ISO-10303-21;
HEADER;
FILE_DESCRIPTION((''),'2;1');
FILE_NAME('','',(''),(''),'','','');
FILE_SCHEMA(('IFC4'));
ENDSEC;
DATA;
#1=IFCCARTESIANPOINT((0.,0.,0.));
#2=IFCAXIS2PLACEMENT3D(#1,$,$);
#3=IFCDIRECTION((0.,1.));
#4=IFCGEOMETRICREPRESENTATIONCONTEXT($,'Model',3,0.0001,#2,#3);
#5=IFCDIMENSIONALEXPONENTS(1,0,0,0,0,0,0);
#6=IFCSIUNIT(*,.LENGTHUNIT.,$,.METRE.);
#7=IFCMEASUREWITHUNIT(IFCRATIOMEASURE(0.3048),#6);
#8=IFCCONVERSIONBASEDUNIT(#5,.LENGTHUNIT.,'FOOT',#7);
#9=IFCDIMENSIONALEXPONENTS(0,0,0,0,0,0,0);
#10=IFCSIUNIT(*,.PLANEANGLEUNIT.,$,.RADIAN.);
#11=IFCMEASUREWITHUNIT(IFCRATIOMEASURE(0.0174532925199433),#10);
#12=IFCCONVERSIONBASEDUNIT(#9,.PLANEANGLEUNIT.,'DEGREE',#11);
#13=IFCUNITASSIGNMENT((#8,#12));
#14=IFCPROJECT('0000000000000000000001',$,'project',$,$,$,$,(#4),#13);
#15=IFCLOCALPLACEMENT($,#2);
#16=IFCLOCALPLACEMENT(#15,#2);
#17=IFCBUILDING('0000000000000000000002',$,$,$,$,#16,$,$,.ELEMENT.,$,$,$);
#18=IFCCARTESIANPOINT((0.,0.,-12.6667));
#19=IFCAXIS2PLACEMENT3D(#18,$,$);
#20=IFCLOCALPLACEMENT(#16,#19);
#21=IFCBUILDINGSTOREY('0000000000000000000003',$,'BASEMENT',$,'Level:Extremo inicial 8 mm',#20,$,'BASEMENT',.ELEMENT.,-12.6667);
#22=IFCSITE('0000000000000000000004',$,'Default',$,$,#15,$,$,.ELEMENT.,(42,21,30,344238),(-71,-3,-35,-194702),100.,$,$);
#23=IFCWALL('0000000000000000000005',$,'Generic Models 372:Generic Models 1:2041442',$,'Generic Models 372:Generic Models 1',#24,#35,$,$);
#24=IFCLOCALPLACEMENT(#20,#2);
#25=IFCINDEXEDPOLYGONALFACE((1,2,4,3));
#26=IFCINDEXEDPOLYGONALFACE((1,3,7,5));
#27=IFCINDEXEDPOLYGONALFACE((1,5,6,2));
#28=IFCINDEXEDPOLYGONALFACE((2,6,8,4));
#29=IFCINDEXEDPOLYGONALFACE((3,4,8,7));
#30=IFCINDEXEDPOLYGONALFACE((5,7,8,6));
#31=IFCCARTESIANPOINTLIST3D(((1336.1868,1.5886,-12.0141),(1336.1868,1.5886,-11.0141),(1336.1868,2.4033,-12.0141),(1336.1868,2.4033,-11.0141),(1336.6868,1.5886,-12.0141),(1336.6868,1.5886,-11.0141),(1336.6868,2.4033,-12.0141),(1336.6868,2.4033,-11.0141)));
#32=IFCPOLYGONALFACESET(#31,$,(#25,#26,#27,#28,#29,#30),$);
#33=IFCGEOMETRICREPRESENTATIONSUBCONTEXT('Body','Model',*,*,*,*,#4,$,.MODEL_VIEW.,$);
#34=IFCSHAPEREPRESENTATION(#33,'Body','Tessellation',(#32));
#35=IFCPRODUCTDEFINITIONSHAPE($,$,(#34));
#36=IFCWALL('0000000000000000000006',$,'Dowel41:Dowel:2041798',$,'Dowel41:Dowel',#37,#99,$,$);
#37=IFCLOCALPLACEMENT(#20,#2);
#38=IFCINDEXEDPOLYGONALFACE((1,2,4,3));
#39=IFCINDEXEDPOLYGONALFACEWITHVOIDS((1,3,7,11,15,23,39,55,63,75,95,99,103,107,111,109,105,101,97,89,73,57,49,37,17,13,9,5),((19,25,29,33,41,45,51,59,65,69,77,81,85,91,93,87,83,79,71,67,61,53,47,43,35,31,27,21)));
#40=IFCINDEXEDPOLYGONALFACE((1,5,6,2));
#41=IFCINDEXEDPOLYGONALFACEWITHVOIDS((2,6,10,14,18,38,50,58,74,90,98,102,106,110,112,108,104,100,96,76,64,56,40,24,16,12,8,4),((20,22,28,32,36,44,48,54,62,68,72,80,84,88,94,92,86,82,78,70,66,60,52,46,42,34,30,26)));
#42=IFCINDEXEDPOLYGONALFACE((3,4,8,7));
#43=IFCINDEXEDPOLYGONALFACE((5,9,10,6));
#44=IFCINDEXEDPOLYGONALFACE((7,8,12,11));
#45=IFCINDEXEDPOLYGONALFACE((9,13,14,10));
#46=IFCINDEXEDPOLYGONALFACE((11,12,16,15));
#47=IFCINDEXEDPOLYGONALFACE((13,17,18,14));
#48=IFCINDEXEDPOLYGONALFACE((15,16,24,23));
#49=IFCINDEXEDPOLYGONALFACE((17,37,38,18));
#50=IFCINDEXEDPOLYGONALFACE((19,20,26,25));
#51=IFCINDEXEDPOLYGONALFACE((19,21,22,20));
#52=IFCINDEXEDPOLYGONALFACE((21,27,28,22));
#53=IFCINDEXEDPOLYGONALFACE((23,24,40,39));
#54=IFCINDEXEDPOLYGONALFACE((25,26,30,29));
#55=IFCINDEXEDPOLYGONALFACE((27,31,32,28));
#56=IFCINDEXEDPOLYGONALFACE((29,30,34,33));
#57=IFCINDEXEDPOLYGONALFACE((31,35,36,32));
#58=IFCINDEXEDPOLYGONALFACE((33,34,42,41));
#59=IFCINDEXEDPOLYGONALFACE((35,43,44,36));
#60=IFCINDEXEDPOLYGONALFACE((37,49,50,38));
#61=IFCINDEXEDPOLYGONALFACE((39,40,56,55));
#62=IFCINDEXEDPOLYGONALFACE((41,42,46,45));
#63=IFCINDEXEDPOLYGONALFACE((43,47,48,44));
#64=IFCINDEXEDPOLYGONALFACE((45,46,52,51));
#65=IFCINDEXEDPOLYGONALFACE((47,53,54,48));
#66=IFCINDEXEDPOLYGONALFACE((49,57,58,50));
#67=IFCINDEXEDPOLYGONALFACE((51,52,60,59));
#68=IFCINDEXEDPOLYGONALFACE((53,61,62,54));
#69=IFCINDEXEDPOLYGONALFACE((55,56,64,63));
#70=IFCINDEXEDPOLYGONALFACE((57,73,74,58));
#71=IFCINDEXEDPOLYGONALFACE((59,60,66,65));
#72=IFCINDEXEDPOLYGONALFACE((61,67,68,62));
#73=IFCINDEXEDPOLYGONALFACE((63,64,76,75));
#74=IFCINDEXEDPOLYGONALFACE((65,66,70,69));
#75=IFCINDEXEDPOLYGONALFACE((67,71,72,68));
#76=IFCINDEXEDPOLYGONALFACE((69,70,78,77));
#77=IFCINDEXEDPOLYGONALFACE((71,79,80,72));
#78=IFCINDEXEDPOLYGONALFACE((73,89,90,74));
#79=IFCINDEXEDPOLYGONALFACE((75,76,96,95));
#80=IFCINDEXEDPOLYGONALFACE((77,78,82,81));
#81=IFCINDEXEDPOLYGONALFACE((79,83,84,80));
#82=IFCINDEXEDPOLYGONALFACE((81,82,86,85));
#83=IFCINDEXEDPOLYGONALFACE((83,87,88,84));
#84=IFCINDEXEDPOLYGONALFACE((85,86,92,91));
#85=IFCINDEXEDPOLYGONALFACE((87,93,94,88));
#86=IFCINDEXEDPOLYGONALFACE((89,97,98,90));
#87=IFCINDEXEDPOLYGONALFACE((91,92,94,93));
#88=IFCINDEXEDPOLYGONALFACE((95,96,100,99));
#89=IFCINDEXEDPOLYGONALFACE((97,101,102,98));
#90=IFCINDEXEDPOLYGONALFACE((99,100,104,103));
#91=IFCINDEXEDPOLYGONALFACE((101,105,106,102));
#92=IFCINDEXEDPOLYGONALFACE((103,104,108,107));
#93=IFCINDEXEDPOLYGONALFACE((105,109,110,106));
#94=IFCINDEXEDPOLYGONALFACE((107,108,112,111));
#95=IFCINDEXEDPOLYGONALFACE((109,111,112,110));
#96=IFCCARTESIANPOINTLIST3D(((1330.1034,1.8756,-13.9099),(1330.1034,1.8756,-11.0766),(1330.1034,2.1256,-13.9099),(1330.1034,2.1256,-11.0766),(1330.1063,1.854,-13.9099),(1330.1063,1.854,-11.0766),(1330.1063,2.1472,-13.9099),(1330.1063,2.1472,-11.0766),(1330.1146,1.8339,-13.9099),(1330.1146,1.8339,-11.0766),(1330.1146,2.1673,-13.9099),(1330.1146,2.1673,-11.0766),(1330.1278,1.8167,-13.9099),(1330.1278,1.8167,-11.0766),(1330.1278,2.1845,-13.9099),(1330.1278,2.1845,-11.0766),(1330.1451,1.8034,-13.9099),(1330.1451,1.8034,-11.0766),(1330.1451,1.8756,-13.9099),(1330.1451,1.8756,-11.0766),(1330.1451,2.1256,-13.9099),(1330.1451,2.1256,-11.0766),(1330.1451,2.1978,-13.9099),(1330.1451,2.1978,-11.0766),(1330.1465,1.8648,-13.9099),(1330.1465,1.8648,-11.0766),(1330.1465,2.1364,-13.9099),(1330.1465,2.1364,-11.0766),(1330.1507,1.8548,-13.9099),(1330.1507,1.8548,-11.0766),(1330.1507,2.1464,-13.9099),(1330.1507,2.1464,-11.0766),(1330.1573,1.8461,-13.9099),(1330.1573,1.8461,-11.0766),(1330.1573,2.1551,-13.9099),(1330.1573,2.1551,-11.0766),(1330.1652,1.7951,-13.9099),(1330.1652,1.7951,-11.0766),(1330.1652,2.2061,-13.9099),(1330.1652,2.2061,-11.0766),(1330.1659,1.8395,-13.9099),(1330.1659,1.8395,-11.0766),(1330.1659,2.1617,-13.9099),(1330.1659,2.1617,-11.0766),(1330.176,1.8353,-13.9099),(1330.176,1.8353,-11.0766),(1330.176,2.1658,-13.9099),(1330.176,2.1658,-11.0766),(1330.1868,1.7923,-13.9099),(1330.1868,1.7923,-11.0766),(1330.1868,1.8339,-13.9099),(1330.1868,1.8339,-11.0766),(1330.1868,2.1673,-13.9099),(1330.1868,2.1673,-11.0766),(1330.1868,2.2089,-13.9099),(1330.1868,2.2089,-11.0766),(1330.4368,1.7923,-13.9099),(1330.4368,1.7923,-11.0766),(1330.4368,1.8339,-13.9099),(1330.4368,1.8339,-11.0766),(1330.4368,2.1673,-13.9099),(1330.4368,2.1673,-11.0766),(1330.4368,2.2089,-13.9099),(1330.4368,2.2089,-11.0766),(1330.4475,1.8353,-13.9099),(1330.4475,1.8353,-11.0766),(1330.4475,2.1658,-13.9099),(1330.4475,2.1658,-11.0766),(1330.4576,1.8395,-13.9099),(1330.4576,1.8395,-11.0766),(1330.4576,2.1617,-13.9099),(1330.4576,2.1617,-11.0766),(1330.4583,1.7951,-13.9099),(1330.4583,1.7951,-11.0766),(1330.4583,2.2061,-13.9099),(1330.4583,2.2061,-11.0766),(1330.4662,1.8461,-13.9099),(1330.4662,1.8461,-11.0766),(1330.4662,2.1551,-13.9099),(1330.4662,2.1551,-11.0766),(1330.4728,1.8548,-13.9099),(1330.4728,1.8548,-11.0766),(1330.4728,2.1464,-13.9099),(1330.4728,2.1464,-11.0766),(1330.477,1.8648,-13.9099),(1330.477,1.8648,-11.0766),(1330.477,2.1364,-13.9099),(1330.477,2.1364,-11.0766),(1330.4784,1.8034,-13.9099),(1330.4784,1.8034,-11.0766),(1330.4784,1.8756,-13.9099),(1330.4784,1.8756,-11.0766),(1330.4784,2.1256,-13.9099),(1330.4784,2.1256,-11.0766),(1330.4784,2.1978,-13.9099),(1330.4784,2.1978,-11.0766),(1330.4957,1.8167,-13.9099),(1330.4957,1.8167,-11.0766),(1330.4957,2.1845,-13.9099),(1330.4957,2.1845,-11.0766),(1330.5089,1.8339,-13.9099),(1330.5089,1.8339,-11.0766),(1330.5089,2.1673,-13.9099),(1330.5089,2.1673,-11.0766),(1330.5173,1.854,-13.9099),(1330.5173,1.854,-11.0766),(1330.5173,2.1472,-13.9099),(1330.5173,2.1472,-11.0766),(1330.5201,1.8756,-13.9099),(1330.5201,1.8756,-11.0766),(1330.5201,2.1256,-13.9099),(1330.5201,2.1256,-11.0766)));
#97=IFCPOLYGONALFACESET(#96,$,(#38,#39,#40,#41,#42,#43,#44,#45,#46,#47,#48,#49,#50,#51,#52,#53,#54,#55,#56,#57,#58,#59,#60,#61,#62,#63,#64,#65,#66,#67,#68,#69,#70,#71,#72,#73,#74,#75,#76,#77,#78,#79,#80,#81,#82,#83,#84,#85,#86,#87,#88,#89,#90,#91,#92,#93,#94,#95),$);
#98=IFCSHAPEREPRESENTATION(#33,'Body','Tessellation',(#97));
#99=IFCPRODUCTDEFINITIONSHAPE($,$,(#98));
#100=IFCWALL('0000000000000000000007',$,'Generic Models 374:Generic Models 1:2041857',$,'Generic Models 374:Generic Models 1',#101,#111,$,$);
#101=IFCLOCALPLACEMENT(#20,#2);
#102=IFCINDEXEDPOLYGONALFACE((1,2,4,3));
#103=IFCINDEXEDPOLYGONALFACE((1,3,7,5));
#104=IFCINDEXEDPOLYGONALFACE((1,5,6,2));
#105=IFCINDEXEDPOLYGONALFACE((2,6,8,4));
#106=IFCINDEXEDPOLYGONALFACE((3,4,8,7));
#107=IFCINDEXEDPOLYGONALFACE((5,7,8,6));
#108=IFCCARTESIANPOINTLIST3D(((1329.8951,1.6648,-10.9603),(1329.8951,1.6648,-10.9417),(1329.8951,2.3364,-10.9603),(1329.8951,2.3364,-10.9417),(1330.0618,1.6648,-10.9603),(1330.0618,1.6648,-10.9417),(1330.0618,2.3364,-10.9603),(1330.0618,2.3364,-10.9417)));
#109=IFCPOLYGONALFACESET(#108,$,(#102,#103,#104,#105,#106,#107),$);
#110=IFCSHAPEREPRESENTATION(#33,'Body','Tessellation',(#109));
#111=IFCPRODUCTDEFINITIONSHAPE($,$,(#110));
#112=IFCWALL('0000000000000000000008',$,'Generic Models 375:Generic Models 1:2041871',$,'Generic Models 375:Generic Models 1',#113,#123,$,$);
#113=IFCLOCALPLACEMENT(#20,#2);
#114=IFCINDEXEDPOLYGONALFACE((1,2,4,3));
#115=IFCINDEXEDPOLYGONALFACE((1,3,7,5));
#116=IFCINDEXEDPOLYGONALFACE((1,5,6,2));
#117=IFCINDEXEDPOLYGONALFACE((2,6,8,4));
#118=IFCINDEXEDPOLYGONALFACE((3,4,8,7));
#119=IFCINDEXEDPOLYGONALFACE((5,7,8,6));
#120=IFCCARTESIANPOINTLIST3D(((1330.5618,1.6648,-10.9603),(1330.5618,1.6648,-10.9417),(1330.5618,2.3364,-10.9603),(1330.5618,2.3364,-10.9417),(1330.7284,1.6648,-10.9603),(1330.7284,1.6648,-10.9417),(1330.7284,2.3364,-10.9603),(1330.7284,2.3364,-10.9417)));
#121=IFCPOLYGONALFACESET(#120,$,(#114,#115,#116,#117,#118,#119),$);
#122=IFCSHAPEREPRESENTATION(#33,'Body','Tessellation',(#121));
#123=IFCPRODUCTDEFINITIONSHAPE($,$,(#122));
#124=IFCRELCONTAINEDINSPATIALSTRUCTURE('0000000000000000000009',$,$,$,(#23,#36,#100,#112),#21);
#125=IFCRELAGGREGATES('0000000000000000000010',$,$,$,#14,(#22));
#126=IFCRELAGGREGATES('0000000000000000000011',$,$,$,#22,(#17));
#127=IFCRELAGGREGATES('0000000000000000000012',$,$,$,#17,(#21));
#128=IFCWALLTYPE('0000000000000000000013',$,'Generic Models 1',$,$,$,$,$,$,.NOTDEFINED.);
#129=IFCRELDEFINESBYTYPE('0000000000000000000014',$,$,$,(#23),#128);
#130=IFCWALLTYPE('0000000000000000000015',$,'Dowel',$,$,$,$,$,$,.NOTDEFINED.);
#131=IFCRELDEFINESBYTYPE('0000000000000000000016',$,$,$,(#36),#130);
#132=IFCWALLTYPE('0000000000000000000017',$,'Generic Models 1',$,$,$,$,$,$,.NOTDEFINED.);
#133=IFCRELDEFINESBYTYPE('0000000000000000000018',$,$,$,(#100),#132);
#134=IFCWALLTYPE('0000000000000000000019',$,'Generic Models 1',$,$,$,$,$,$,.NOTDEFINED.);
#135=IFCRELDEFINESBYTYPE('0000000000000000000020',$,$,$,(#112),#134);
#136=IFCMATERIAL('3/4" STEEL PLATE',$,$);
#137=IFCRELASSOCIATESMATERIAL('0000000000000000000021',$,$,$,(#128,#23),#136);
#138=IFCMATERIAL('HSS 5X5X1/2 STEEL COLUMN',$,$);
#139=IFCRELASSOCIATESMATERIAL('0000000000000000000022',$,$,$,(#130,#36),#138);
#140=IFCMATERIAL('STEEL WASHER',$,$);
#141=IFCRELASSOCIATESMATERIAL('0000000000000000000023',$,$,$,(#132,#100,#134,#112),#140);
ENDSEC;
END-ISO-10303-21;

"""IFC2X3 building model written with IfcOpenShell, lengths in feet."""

from ifc_helpers import new_model, entity, si_unit, converted_unit, direction, frame, frame_2d, origin, origin_2d_with_axis, place, context, subcontext, project, spatial, polyline, circle_curve, parameter, trimmed, segment, composite_curve, rectangle, outline, extrude, material, type_object, element, save


model = new_model("IFC2X3")

# Units and contexts
model_context = context("Model", 3, precision=0.0001, world=origin(), true_north=direction((0.0, 1.0)))
body_context = subcontext(model_context, "Body", "Model", "MODEL_VIEW")
ifc_project = project(units=[converted_unit("LENGTHUNIT", "FOOT", entity("IfcRatioMeasure", 0.3048), si_unit("LENGTHUNIT", "METRE"), dimensions=[1, 0, 0, 0, 0, 0, 0]), converted_unit("PLANEANGLEUNIT", "DEGREE", entity("IfcRatioMeasure", 0.0174532925199433), si_unit("PLANEANGLEUNIT", "RADIAN"), dimensions=[0, 0, 0, 0, 0, 0, 0])], contexts=[model_context])

# Site, building, storey
site_placement = place(None, origin())
site = spatial("IfcSite", under=ifc_project, at=site_placement, Name="Default", CompositionType="ELEMENT", RefLatitude=(42, 21, 30, 344238), RefLongitude=(-71, -3, -35, -194702), RefElevation=100.0)
building_placement = place(site_placement, origin())
building = spatial("IfcBuilding", under=site, at=building_placement, CompositionType="ELEMENT")
storey_placement = place(building_placement, frame((0.0, 0.0, -12.6667)))
storey = spatial("IfcBuildingStorey", under=building, at=storey_placement, Name="BASEMENT", ObjectType="Level:Extremo inicial 8 mm", LongName="BASEMENT", CompositionType="ELEMENT", Elevation=-12.6667)

# Wall
ifc_material_1 = material(Name="3/4\" STEEL PLATE")
wall_type_1 = type_object("IfcWallType", Name="Generic Models 1", PredefinedType="NOTDEFINED", material=ifc_material_1)
wall_1_placement = place(storey_placement, frame((1336.1868, 1.5886, -12.0141), z_axis=(0.0, 0.0, 1.0), x_axis=(0.0, 1.0, 0.0)))
element("IfcWall", 1, at=wall_1_placement, inside=storey, type_object=wall_type_1, material=ifc_material_1, Name="Generic Models 372:Generic Models 1:2041442", ObjectType="Generic Models 372:Generic Models 1", context=body_context, shape_type="SweptSolid", body=[
    extrude(rectangle(XDim=0.8147, YDim=0.5, at=origin_2d_with_axis()), frame((0.4074, -0.25, 0.0)), (0.0, 0.0, 1.0), 1.0),
])

# Wall, opening
ifc_material_2 = material(Name="HSS 5X5X1/2 STEEL COLUMN")
wall_type_2 = type_object("IfcWallType", Name="Dowel", PredefinedType="NOTDEFINED", material=ifc_material_2)
wall_2_placement = place(storey_placement, frame((1330.1034, 1.7923, -13.9099)))
wall_2 = element("IfcWall", 2, at=wall_2_placement, inside=storey, type_object=wall_type_2, material=ifc_material_2, Name="Dowel41:Dowel:2041798", ObjectType="Dowel41:Dowel", context=body_context, shape_type="SweptSolid", body=[
    extrude(outline(composite_curve([segment(polyline([(-0.125, -0.2083), (0.125, -0.2083)]), True, "CONTINUOUS"), segment(trimmed(circle_curve(frame_2d((0.125, -0.125), x_axis=(0.0, 1.0)), 0.0833), [parameter(180.0)], [parameter(270.0)], True, "PARAMETER"), True, "CONTINUOUS"), segment(polyline([(0.2083, -0.125), (0.2083, 0.125)]), True, "CONTINUOUS"), segment(trimmed(circle_curve(frame_2d((0.125, 0.125), x_axis=(0.0, 1.0)), 0.0833), [parameter(270.0)], [parameter(0.0)], True, "PARAMETER"), True, "CONTINUOUS"), segment(polyline([(0.125, 0.2083), (-0.125, 0.2083)]), True, "CONTINUOUS"), segment(trimmed(circle_curve(frame_2d((-0.125, 0.125), x_axis=(0.0, 1.0)), 0.0833), [parameter(360.0)], [parameter(90.0)], True, "PARAMETER"), True, "CONTINUOUS"), segment(polyline([(-0.2083, 0.125), (-0.2083, -0.125)]), True, "CONTINUOUS"), segment(trimmed(circle_curve(frame_2d((-0.125, -0.125), x_axis=(0.0, 1.0)), 0.0833), [parameter(90.0)], [parameter(180.0)], True, "PARAMETER"), True, "CONTINUOUS")], self_intersect=False)), frame((0.2083, 0.2083, 0.0), z_axis=(0.0, 0.0, 1.0), x_axis=(0.0, 1.0, 0.0)), (0.0, 0.0, 1.0), 2.8333),
])
opening_placement = place(storey_placement, frame((1330.1034, 1.7923, -13.9099)))
element("IfcOpeningElement", 3, at=opening_placement, cuts=wall_2, ObjectType="Opening", context=body_context, shape_type="SweptSolid", body=[
    extrude(outline(composite_curve([segment(polyline([(-0.125, -0.1667), (0.125, -0.1667)]), True, "CONTINUOUS"), segment(trimmed(circle_curve(frame_2d((0.125, -0.125), x_axis=(0.0, 1.0)), 0.0417), [parameter(180.0)], [parameter(270.0)], True, "PARAMETER"), True, "CONTINUOUS"), segment(polyline([(0.1667, -0.125), (0.1667, 0.125)]), True, "CONTINUOUS"), segment(trimmed(circle_curve(frame_2d((0.125, 0.125), x_axis=(0.0, 1.0)), 0.0417), [parameter(270.0)], [parameter(360.0)], True, "PARAMETER"), True, "CONTINUOUS"), segment(polyline([(0.125, 0.1667), (-0.125, 0.1667)]), True, "CONTINUOUS"), segment(trimmed(circle_curve(frame_2d((-0.125, 0.125), x_axis=(0.0, 1.0)), 0.0417), [parameter(0.0)], [parameter(90.0)], True, "PARAMETER"), True, "CONTINUOUS"), segment(polyline([(-0.1667, 0.125), (-0.1667, -0.125)]), True, "CONTINUOUS"), segment(trimmed(circle_curve(frame_2d((-0.125, -0.125), x_axis=(0.0, 1.0)), 0.0417), [parameter(90.0)], [parameter(180.0)], True, "PARAMETER"), True, "CONTINUOUS")], self_intersect=False)), frame((0.2083, 0.2083, 0.0), z_axis=(0.0, 0.0, 1.0), x_axis=(0.0, 1.0, 0.0)), (0.0, 0.0, 1.0), 2.8333),
])

# Walls
ifc_material_3 = material(Name="STEEL WASHER")
wall_type_3 = type_object("IfcWallType", Name="Generic Models 1", PredefinedType="NOTDEFINED", material=ifc_material_3)
wall_3_placement = place(storey_placement, frame((1329.8951, 1.6648, -10.9603), z_axis=(0.0, 0.0, 1.0), x_axis=(0.0, 1.0, 0.0)))
element("IfcWall", 4, at=wall_3_placement, inside=storey, type_object=wall_type_3, material=ifc_material_3, Name="Generic Models 374:Generic Models 1:2041857", ObjectType="Generic Models 374:Generic Models 1", context=body_context, shape_type="SweptSolid", body=[
    extrude(rectangle(XDim=0.6717, YDim=0.1667, at=frame_2d((0.0, 0.0), x_axis=(1.0, 0.0))), frame((0.3358, -0.0833, 0.0)), (0.0, 0.0, 1.0), 0.0187),
])
wall_type_4 = type_object("IfcWallType", Name="Generic Models 1", PredefinedType="NOTDEFINED", material=ifc_material_3)
wall_4_placement = place(storey_placement, frame((1330.5618, 1.6648, -10.9603), z_axis=(0.0, 0.0, 1.0), x_axis=(0.0, 1.0, 0.0)))
element("IfcWall", 5, at=wall_4_placement, inside=storey, type_object=wall_type_4, material=ifc_material_3, Name="Generic Models 375:Generic Models 1:2041871", ObjectType="Generic Models 375:Generic Models 1", context=body_context, shape_type="SweptSolid", body=[
    extrude(rectangle(XDim=0.6717, YDim=0.1667, at=frame_2d((0.0, 0.0), x_axis=(1.0, 0.0))), frame((0.3358, -0.0833, 0.0)), (0.0, 0.0, 1.0), 0.0187),
])

save(model, "model.ifc")
